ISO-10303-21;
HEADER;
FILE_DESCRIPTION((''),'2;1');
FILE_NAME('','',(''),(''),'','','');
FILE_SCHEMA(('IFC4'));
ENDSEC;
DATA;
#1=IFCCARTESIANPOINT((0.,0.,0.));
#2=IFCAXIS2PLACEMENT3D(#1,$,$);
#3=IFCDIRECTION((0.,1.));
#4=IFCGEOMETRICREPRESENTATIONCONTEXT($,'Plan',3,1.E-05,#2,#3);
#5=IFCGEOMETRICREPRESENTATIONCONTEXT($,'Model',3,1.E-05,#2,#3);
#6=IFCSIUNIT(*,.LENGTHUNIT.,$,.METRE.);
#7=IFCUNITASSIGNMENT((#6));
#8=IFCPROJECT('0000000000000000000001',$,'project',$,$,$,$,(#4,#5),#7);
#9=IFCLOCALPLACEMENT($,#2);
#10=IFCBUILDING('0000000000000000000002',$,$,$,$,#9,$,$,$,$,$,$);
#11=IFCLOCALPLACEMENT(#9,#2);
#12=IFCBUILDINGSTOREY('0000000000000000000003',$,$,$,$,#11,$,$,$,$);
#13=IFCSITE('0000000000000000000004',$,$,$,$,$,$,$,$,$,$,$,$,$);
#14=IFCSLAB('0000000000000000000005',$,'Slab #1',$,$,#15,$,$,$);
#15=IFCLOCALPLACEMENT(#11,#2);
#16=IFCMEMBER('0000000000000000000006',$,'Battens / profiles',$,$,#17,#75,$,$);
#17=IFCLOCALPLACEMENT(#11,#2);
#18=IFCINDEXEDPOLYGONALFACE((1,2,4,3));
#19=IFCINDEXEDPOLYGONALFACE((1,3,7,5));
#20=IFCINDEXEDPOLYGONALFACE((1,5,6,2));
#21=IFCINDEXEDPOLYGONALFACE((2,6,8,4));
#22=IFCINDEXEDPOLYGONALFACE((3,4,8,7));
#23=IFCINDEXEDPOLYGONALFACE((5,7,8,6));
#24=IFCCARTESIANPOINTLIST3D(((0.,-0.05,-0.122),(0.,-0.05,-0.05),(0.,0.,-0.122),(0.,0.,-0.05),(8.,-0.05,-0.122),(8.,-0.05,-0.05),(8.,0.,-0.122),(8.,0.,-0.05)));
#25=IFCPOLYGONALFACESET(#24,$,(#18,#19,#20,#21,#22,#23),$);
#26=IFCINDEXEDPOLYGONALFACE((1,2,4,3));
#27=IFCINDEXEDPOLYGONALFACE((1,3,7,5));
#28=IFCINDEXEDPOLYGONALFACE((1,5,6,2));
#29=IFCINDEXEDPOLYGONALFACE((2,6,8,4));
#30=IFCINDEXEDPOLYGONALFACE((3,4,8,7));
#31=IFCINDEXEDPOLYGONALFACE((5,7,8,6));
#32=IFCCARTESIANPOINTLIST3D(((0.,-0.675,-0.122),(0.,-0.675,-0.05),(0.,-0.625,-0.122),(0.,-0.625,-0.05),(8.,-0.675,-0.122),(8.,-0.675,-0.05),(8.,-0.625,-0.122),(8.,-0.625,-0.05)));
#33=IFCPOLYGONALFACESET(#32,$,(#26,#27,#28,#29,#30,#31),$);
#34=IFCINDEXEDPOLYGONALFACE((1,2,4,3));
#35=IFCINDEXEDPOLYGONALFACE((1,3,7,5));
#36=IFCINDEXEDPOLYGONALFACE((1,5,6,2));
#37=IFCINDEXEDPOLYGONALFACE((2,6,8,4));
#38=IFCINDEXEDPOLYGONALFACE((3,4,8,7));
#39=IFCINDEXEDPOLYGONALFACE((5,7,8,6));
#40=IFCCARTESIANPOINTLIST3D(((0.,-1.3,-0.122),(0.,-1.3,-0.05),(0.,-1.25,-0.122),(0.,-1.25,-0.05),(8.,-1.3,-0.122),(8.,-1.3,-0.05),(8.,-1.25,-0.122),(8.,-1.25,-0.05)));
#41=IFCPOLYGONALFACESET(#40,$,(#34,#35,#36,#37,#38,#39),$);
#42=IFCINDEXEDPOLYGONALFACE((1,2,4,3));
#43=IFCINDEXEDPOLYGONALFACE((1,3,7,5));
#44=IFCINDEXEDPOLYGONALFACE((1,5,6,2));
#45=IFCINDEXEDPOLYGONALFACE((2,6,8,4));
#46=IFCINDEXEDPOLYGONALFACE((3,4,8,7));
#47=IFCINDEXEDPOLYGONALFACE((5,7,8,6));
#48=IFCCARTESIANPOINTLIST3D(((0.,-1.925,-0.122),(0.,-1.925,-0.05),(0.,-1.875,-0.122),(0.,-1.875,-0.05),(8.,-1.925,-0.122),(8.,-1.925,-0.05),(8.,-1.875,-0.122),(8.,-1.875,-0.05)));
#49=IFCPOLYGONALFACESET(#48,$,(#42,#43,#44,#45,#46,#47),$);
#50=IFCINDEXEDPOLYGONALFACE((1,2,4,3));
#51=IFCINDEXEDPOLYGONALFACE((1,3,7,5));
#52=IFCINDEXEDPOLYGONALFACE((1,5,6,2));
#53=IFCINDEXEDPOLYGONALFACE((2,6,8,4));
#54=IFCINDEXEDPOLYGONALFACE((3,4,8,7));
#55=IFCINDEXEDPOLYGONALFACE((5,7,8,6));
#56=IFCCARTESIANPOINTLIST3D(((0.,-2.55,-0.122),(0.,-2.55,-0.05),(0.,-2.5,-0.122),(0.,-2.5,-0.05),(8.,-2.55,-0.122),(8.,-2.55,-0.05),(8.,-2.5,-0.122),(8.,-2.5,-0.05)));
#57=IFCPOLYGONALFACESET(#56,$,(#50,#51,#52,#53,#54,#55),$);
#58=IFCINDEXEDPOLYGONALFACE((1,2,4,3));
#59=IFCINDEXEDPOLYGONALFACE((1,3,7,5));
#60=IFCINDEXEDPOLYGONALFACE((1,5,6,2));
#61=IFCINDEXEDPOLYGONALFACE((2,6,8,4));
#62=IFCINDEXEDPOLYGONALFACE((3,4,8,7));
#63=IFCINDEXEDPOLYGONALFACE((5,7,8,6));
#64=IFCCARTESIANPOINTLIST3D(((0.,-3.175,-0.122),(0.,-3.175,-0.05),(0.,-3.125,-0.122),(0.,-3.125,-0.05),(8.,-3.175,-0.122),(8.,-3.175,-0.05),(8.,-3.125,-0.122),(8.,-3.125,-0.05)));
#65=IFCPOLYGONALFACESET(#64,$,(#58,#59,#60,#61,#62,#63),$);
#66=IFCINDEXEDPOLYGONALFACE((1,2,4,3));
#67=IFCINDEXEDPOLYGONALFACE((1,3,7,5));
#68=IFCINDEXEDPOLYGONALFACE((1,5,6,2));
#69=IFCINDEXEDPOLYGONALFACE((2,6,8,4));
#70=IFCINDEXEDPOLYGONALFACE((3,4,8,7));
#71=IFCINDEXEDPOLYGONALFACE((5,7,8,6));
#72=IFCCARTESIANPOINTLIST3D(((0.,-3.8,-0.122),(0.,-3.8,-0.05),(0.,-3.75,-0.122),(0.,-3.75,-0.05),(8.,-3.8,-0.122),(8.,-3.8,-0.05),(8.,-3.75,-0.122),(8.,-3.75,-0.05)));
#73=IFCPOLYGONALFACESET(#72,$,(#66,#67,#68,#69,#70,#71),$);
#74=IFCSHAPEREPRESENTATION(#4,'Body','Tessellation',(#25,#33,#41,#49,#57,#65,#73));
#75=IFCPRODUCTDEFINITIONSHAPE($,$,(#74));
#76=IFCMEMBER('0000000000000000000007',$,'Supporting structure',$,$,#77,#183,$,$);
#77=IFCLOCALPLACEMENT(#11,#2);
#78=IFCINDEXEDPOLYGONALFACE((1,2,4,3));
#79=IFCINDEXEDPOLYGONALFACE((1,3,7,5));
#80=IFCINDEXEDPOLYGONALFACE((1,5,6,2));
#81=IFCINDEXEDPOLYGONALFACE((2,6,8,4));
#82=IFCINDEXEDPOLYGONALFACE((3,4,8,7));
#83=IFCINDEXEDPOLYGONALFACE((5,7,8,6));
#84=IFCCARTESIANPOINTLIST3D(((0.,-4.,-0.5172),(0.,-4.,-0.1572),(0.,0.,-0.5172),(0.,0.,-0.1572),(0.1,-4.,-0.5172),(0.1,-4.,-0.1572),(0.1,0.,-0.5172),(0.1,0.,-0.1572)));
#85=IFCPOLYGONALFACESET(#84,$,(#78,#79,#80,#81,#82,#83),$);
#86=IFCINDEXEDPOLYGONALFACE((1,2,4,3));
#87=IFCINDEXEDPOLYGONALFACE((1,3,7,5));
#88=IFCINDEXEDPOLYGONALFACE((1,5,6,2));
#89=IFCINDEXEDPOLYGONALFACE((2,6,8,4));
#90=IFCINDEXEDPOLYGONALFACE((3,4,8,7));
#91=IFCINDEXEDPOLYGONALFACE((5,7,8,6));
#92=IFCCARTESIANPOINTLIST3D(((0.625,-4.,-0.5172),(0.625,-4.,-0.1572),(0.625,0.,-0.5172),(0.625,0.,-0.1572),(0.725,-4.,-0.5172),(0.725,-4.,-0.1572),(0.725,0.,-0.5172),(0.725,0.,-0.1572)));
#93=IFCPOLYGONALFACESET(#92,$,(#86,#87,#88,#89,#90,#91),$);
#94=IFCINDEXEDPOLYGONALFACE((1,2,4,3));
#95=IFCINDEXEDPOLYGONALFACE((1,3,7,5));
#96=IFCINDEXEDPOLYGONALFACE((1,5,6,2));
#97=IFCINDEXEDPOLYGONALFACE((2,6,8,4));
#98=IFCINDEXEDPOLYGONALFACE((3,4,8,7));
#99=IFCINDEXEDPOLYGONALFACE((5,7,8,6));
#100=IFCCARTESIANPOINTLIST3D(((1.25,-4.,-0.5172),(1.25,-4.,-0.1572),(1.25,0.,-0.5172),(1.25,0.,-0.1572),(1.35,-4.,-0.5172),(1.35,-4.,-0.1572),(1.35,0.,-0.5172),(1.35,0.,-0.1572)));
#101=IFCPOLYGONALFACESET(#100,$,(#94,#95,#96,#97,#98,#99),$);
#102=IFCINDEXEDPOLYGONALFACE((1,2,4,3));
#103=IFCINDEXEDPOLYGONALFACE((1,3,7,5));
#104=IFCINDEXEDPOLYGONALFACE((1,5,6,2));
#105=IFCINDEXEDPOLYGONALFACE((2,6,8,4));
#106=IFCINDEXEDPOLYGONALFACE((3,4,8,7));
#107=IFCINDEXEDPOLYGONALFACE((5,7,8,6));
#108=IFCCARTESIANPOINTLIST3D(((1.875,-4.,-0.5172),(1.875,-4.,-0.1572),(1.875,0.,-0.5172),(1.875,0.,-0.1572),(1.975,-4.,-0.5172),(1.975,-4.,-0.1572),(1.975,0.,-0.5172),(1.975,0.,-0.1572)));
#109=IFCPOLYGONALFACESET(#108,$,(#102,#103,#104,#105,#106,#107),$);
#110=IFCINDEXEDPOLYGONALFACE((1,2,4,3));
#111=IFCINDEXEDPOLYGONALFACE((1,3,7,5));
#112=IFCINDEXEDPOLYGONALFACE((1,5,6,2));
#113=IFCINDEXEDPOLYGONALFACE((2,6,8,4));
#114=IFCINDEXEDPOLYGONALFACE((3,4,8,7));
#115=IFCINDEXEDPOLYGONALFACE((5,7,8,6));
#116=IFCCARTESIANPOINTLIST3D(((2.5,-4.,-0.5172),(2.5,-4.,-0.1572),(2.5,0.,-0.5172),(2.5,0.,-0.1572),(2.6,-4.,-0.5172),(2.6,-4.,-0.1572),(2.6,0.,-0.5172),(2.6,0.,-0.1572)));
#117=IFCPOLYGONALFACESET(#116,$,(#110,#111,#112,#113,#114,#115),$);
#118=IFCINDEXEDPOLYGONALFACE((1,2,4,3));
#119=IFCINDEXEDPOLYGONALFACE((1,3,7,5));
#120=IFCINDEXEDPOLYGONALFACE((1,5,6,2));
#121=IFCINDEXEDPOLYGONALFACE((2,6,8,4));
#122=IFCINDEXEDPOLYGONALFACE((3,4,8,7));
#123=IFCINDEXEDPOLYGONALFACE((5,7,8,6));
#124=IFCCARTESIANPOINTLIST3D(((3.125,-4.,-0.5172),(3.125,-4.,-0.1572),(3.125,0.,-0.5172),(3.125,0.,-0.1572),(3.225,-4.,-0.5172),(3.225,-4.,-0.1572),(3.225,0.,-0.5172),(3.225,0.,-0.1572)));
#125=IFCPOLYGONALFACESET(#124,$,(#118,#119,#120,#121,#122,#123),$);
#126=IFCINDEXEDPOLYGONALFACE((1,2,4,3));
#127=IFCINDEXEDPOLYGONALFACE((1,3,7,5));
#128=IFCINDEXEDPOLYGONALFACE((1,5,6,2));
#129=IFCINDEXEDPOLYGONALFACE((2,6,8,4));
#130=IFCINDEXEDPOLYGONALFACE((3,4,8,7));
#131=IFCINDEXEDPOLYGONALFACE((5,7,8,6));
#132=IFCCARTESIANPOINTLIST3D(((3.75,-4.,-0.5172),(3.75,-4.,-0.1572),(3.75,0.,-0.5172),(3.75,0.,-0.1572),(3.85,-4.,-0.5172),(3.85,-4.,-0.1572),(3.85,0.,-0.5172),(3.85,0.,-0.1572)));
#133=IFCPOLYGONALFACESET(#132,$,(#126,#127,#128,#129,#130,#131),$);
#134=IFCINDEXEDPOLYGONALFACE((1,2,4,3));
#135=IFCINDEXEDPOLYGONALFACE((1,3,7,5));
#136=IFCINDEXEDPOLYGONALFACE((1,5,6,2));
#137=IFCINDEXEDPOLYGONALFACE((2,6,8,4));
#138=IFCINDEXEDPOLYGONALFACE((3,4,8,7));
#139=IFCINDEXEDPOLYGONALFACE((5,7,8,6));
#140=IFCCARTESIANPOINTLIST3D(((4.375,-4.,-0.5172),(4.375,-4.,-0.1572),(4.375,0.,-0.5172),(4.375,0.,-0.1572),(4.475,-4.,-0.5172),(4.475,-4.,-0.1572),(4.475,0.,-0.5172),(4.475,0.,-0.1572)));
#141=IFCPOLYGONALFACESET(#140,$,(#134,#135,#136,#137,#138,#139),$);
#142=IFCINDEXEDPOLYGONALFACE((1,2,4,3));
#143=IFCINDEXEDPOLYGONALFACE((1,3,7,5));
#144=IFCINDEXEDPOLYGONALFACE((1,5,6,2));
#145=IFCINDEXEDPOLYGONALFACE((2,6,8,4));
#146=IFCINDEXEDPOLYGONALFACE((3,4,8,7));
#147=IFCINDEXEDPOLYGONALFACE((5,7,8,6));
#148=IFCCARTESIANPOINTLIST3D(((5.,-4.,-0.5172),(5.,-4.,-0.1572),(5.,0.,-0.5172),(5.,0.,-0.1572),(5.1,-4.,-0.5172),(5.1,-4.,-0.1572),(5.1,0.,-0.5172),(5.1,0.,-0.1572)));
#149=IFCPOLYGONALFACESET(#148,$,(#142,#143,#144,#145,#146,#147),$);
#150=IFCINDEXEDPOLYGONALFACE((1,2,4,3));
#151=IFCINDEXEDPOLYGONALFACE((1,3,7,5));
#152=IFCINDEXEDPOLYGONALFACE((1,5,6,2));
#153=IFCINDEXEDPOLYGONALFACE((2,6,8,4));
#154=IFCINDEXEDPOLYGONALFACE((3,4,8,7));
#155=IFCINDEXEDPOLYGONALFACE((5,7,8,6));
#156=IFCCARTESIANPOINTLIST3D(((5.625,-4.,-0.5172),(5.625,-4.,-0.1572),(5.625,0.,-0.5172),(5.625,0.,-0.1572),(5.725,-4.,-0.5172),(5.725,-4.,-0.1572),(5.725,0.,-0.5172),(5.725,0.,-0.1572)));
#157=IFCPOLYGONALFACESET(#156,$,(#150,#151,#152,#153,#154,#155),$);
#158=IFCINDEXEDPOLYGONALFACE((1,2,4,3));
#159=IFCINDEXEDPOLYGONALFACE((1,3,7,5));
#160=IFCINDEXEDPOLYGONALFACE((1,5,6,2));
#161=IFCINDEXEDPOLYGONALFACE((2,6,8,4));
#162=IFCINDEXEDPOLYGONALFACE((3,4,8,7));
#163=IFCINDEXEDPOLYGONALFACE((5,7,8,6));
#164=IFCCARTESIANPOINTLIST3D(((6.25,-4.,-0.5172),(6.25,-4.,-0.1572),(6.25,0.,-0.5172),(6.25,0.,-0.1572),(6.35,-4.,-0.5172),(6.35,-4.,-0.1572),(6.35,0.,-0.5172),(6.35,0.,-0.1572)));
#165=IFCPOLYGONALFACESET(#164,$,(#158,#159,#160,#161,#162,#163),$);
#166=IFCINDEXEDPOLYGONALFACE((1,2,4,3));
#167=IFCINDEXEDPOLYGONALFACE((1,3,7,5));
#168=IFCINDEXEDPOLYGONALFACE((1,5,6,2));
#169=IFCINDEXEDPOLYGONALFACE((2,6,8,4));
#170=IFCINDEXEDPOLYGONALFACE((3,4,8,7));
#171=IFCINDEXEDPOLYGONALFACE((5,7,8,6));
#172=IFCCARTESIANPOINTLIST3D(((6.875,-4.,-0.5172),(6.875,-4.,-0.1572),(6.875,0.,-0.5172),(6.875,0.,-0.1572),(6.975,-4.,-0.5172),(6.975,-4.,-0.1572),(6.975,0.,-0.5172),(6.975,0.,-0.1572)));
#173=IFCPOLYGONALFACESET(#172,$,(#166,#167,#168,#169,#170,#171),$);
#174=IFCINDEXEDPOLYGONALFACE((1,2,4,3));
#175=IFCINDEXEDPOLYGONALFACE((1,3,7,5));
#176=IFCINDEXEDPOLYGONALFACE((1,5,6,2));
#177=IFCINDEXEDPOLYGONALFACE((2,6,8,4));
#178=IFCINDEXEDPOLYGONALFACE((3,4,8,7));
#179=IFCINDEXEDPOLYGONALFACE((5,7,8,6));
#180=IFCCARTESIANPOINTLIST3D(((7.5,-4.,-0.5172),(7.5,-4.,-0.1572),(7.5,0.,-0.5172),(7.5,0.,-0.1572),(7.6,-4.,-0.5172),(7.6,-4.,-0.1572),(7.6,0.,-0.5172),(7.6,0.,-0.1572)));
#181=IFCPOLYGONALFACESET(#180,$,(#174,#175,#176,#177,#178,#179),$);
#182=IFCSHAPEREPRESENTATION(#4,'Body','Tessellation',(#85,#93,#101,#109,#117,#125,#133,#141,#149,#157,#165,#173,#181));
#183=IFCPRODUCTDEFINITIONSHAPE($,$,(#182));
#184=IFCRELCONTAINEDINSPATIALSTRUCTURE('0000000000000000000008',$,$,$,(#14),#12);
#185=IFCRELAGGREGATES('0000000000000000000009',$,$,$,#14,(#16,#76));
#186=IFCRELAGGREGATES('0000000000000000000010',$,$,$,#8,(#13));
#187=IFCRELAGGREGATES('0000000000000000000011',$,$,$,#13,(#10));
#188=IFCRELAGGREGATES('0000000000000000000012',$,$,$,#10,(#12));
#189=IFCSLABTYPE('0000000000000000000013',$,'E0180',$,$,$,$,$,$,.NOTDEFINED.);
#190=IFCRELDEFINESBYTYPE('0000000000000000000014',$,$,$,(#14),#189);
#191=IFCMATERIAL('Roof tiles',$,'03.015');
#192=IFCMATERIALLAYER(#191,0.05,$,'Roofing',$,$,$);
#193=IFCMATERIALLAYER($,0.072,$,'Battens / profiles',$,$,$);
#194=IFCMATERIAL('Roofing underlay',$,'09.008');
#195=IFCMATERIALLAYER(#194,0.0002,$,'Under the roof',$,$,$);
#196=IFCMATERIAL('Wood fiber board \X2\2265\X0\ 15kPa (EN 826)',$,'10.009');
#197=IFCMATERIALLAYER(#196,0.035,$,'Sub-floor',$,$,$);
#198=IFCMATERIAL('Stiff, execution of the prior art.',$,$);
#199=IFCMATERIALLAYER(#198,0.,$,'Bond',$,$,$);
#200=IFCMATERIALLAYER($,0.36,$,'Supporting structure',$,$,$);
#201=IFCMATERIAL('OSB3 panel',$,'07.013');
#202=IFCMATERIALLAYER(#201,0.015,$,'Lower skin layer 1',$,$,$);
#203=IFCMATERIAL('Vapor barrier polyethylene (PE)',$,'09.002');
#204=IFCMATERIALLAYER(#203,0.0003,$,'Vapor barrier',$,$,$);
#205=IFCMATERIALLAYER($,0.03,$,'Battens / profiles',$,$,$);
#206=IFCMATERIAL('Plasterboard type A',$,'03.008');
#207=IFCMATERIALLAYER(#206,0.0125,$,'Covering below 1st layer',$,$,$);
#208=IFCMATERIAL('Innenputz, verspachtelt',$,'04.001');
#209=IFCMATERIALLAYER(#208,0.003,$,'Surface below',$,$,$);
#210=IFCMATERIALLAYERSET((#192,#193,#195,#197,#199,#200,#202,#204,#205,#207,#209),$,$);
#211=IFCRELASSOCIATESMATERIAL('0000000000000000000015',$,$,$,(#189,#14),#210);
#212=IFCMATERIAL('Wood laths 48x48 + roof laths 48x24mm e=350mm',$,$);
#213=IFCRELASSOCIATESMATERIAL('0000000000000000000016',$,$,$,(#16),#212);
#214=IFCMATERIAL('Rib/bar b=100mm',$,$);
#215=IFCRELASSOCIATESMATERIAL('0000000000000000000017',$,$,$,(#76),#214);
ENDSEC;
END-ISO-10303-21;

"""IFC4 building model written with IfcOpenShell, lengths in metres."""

from ifc_helpers import new_model, si_unit, direction, frame, frame_2d, origin, place, context, project, spatial, rectangle, extrude, material, layer, layer_set, type_object, element, aggregate, save


model = new_model("IFC4")

# Units and contexts
plan_context = context("Plan", 3, precision=1e-05, world=origin(), true_north=direction((0.0, 1.0)))
model_context = context("Model", 3, precision=1e-05, world=origin(), true_north=direction((0.0, 1.0)))
ifc_project = project(units=[si_unit("LENGTHUNIT", "METRE")], contexts=[plan_context, model_context])

# Site, building, storey
site = spatial("IfcSite", under=ifc_project)
building_placement = place(None, origin())
building = spatial("IfcBuilding", under=site, at=building_placement)
storey_placement = place(building_placement, origin())
storey = spatial("IfcBuildingStorey", under=building, at=storey_placement)

# Slab, members
ifc_material_1 = material(Name="Roof tiles", Category="03.015")
ifc_layer_1 = layer(ifc_material_1, 0.05, Name="Roofing")
ifc_layer_2 = layer(None, 0.072, Name="Battens / profiles")
ifc_material_2 = material(Name="Roofing underlay", Category="09.008")
ifc_layer_3 = layer(ifc_material_2, 0.0002, Name="Under the roof")
ifc_material_3 = material(Name="Wood fiber board ≥ 15kPa (EN 826)", Category="10.009")
ifc_layer_4 = layer(ifc_material_3, 0.035, Name="Sub-floor")
ifc_material_4 = material(Name="Stiff, execution of the prior art.")
ifc_layer_5 = layer(ifc_material_4, 0.0, Name="Bond")
ifc_layer_6 = layer(None, 0.36, Name="Supporting structure")
ifc_material_5 = material(Name="OSB3 panel", Category="07.013")
ifc_layer_7 = layer(ifc_material_5, 0.015, Name="Lower skin layer 1")
ifc_material_6 = material(Name="Vapor barrier polyethylene (PE)", Category="09.002")
ifc_layer_8 = layer(ifc_material_6, 0.0003, Name="Vapor barrier")
ifc_layer_9 = layer(None, 0.03, Name="Battens / profiles")
ifc_material_7 = material(Name="Plasterboard type A", Category="03.008")
ifc_layer_10 = layer(ifc_material_7, 0.0125, Name="Covering below 1st layer")
ifc_material_8 = material(Name="Innenputz, verspachtelt", Category="04.001")
ifc_layer_11 = layer(ifc_material_8, 0.003, Name="Surface below")
ifc_layer_set = layer_set([ifc_layer_1, ifc_layer_2, ifc_layer_3, ifc_layer_4, ifc_layer_5, ifc_layer_6, ifc_layer_7, ifc_layer_8, ifc_layer_9, ifc_layer_10, ifc_layer_11])
slab_type = type_object("IfcSlabType", Name="E0180", PredefinedType="NOTDEFINED", material=ifc_layer_set)
slab_placement = place(None, frame((0.0, 0.0, 0.0), z_axis=(0.0, 0.0, -1.0), x_axis=(1.0, 0.0, 0.0)))
slab = element("IfcSlab", 1, at=slab_placement, inside=storey, type_object=slab_type, material=ifc_layer_set, Name="Slab #1")
ifc_material_9 = material(Name="Wood laths 48x48 + roof laths 48x24mm e=350mm")
member_1_placement = place(slab_placement, origin())
member_1 = element("IfcMember", 2, at=member_1_placement, material=ifc_material_9, Name="Battens / profiles", context=plan_context, shape_type="SweptSolid", body=[
    extrude(rectangle(XDim=0.05, YDim=0.072, at=frame_2d((0.025, 0.036), x_axis=(1.0, 0.0))), frame((0.0, 0.0, 0.05), z_axis=(1.0, 0.0, 0.0), x_axis=(0.0, 1.0, 0.0)), (0.0, 0.0, 1.0), 8.0),
    extrude(rectangle(XDim=0.05, YDim=0.072, at=frame_2d((0.025, 0.036), x_axis=(1.0, 0.0))), frame((0.0, 0.625, 0.05), z_axis=(1.0, 0.0, 0.0), x_axis=(0.0, 1.0, 0.0)), (0.0, 0.0, 1.0), 8.0),
    extrude(rectangle(XDim=0.05, YDim=0.072, at=frame_2d((0.025, 0.036), x_axis=(1.0, 0.0))), frame((0.0, 1.25, 0.05), z_axis=(1.0, 0.0, 0.0), x_axis=(0.0, 1.0, 0.0)), (0.0, 0.0, 1.0), 8.0),
    extrude(rectangle(XDim=0.05, YDim=0.072, at=frame_2d((0.025, 0.036), x_axis=(1.0, 0.0))), frame((0.0, 1.875, 0.05), z_axis=(1.0, 0.0, 0.0), x_axis=(0.0, 1.0, 0.0)), (0.0, 0.0, 1.0), 8.0),
    extrude(rectangle(XDim=0.05, YDim=0.072, at=frame_2d((0.025, 0.036), x_axis=(1.0, 0.0))), frame((0.0, 2.5, 0.05), z_axis=(1.0, 0.0, 0.0), x_axis=(0.0, 1.0, 0.0)), (0.0, 0.0, 1.0), 8.0),
    extrude(rectangle(XDim=0.05, YDim=0.072, at=frame_2d((0.025, 0.036), x_axis=(1.0, 0.0))), frame((0.0, 3.125, 0.05), z_axis=(1.0, 0.0, 0.0), x_axis=(0.0, 1.0, 0.0)), (0.0, 0.0, 1.0), 8.0),
    extrude(rectangle(XDim=0.05, YDim=0.072, at=frame_2d((0.025, 0.036), x_axis=(1.0, 0.0))), frame((0.0, 3.75, 0.05), z_axis=(1.0, 0.0, 0.0), x_axis=(0.0, 1.0, 0.0)), (0.0, 0.0, 1.0), 8.0),
])
ifc_material_10 = material(Name="Rib/bar b=100mm")
member_2_placement = place(slab_placement, origin())
member_2 = element("IfcMember", 3, at=member_2_placement, material=ifc_material_10, Name="Supporting structure", context=plan_context, shape_type="SweptSolid", body=[
    extrude(rectangle(XDim=0.1, YDim=0.36, at=frame_2d((0.05, 0.18), x_axis=(1.0, 0.0))), frame((0.0, 4.0, 0.1572), z_axis=(0.0, -1.0, 0.0), x_axis=(1.0, 0.0, 0.0)), (0.0, 0.0, 1.0), 4.0),
    extrude(rectangle(XDim=0.1, YDim=0.36, at=frame_2d((0.05, 0.18), x_axis=(1.0, 0.0))), frame((0.625, 4.0, 0.1572), z_axis=(0.0, -1.0, 0.0), x_axis=(1.0, 0.0, 0.0)), (0.0, 0.0, 1.0), 4.0),
    extrude(rectangle(XDim=0.1, YDim=0.36, at=frame_2d((0.05, 0.18), x_axis=(1.0, 0.0))), frame((1.25, 4.0, 0.1572), z_axis=(0.0, -1.0, 0.0), x_axis=(1.0, 0.0, 0.0)), (0.0, 0.0, 1.0), 4.0),
    extrude(rectangle(XDim=0.1, YDim=0.36, at=frame_2d((0.05, 0.18), x_axis=(1.0, 0.0))), frame((1.875, 4.0, 0.1572), z_axis=(0.0, -1.0, 0.0), x_axis=(1.0, 0.0, 0.0)), (0.0, 0.0, 1.0), 4.0),
    extrude(rectangle(XDim=0.1, YDim=0.36, at=frame_2d((0.05, 0.18), x_axis=(1.0, 0.0))), frame((2.5, 4.0, 0.1572), z_axis=(0.0, -1.0, 0.0), x_axis=(1.0, 0.0, 0.0)), (0.0, 0.0, 1.0), 4.0),
    extrude(rectangle(XDim=0.1, YDim=0.36, at=frame_2d((0.05, 0.18), x_axis=(1.0, 0.0))), frame((3.125, 4.0, 0.1572), z_axis=(0.0, -1.0, 0.0), x_axis=(1.0, 0.0, 0.0)), (0.0, 0.0, 1.0), 4.0),
    extrude(rectangle(XDim=0.1, YDim=0.36, at=frame_2d((0.05, 0.18), x_axis=(1.0, 0.0))), frame((3.75, 4.0, 0.1572), z_axis=(0.0, -1.0, 0.0), x_axis=(1.0, 0.0, 0.0)), (0.0, 0.0, 1.0), 4.0),
    extrude(rectangle(XDim=0.1, YDim=0.36, at=frame_2d((0.05, 0.18), x_axis=(1.0, 0.0))), frame((4.375, 4.0, 0.1572), z_axis=(0.0, -1.0, 0.0), x_axis=(1.0, 0.0, 0.0)), (0.0, 0.0, 1.0), 4.0),
    extrude(rectangle(XDim=0.1, YDim=0.36, at=frame_2d((0.05, 0.18), x_axis=(1.0, 0.0))), frame((5.0, 4.0, 0.1572), z_axis=(0.0, -1.0, 0.0), x_axis=(1.0, 0.0, 0.0)), (0.0, 0.0, 1.0), 4.0),
    extrude(rectangle(XDim=0.1, YDim=0.36, at=frame_2d((0.05, 0.18), x_axis=(1.0, 0.0))), frame((5.625, 4.0, 0.1572), z_axis=(0.0, -1.0, 0.0), x_axis=(1.0, 0.0, 0.0)), (0.0, 0.0, 1.0), 4.0),
    extrude(rectangle(XDim=0.1, YDim=0.36, at=frame_2d((0.05, 0.18), x_axis=(1.0, 0.0))), frame((6.25, 4.0, 0.1572), z_axis=(0.0, -1.0, 0.0), x_axis=(1.0, 0.0, 0.0)), (0.0, 0.0, 1.0), 4.0),
    extrude(rectangle(XDim=0.1, YDim=0.36, at=frame_2d((0.05, 0.18), x_axis=(1.0, 0.0))), frame((6.875, 4.0, 0.1572), z_axis=(0.0, -1.0, 0.0), x_axis=(1.0, 0.0, 0.0)), (0.0, 0.0, 1.0), 4.0),
    extrude(rectangle(XDim=0.1, YDim=0.36, at=frame_2d((0.05, 0.18), x_axis=(1.0, 0.0))), frame((7.5, 4.0, 0.1572), z_axis=(0.0, -1.0, 0.0), x_axis=(1.0, 0.0, 0.0)), (0.0, 0.0, 1.0), 4.0),
])
aggregate(slab, [member_1, member_2])

save(model, "model.ifc")
